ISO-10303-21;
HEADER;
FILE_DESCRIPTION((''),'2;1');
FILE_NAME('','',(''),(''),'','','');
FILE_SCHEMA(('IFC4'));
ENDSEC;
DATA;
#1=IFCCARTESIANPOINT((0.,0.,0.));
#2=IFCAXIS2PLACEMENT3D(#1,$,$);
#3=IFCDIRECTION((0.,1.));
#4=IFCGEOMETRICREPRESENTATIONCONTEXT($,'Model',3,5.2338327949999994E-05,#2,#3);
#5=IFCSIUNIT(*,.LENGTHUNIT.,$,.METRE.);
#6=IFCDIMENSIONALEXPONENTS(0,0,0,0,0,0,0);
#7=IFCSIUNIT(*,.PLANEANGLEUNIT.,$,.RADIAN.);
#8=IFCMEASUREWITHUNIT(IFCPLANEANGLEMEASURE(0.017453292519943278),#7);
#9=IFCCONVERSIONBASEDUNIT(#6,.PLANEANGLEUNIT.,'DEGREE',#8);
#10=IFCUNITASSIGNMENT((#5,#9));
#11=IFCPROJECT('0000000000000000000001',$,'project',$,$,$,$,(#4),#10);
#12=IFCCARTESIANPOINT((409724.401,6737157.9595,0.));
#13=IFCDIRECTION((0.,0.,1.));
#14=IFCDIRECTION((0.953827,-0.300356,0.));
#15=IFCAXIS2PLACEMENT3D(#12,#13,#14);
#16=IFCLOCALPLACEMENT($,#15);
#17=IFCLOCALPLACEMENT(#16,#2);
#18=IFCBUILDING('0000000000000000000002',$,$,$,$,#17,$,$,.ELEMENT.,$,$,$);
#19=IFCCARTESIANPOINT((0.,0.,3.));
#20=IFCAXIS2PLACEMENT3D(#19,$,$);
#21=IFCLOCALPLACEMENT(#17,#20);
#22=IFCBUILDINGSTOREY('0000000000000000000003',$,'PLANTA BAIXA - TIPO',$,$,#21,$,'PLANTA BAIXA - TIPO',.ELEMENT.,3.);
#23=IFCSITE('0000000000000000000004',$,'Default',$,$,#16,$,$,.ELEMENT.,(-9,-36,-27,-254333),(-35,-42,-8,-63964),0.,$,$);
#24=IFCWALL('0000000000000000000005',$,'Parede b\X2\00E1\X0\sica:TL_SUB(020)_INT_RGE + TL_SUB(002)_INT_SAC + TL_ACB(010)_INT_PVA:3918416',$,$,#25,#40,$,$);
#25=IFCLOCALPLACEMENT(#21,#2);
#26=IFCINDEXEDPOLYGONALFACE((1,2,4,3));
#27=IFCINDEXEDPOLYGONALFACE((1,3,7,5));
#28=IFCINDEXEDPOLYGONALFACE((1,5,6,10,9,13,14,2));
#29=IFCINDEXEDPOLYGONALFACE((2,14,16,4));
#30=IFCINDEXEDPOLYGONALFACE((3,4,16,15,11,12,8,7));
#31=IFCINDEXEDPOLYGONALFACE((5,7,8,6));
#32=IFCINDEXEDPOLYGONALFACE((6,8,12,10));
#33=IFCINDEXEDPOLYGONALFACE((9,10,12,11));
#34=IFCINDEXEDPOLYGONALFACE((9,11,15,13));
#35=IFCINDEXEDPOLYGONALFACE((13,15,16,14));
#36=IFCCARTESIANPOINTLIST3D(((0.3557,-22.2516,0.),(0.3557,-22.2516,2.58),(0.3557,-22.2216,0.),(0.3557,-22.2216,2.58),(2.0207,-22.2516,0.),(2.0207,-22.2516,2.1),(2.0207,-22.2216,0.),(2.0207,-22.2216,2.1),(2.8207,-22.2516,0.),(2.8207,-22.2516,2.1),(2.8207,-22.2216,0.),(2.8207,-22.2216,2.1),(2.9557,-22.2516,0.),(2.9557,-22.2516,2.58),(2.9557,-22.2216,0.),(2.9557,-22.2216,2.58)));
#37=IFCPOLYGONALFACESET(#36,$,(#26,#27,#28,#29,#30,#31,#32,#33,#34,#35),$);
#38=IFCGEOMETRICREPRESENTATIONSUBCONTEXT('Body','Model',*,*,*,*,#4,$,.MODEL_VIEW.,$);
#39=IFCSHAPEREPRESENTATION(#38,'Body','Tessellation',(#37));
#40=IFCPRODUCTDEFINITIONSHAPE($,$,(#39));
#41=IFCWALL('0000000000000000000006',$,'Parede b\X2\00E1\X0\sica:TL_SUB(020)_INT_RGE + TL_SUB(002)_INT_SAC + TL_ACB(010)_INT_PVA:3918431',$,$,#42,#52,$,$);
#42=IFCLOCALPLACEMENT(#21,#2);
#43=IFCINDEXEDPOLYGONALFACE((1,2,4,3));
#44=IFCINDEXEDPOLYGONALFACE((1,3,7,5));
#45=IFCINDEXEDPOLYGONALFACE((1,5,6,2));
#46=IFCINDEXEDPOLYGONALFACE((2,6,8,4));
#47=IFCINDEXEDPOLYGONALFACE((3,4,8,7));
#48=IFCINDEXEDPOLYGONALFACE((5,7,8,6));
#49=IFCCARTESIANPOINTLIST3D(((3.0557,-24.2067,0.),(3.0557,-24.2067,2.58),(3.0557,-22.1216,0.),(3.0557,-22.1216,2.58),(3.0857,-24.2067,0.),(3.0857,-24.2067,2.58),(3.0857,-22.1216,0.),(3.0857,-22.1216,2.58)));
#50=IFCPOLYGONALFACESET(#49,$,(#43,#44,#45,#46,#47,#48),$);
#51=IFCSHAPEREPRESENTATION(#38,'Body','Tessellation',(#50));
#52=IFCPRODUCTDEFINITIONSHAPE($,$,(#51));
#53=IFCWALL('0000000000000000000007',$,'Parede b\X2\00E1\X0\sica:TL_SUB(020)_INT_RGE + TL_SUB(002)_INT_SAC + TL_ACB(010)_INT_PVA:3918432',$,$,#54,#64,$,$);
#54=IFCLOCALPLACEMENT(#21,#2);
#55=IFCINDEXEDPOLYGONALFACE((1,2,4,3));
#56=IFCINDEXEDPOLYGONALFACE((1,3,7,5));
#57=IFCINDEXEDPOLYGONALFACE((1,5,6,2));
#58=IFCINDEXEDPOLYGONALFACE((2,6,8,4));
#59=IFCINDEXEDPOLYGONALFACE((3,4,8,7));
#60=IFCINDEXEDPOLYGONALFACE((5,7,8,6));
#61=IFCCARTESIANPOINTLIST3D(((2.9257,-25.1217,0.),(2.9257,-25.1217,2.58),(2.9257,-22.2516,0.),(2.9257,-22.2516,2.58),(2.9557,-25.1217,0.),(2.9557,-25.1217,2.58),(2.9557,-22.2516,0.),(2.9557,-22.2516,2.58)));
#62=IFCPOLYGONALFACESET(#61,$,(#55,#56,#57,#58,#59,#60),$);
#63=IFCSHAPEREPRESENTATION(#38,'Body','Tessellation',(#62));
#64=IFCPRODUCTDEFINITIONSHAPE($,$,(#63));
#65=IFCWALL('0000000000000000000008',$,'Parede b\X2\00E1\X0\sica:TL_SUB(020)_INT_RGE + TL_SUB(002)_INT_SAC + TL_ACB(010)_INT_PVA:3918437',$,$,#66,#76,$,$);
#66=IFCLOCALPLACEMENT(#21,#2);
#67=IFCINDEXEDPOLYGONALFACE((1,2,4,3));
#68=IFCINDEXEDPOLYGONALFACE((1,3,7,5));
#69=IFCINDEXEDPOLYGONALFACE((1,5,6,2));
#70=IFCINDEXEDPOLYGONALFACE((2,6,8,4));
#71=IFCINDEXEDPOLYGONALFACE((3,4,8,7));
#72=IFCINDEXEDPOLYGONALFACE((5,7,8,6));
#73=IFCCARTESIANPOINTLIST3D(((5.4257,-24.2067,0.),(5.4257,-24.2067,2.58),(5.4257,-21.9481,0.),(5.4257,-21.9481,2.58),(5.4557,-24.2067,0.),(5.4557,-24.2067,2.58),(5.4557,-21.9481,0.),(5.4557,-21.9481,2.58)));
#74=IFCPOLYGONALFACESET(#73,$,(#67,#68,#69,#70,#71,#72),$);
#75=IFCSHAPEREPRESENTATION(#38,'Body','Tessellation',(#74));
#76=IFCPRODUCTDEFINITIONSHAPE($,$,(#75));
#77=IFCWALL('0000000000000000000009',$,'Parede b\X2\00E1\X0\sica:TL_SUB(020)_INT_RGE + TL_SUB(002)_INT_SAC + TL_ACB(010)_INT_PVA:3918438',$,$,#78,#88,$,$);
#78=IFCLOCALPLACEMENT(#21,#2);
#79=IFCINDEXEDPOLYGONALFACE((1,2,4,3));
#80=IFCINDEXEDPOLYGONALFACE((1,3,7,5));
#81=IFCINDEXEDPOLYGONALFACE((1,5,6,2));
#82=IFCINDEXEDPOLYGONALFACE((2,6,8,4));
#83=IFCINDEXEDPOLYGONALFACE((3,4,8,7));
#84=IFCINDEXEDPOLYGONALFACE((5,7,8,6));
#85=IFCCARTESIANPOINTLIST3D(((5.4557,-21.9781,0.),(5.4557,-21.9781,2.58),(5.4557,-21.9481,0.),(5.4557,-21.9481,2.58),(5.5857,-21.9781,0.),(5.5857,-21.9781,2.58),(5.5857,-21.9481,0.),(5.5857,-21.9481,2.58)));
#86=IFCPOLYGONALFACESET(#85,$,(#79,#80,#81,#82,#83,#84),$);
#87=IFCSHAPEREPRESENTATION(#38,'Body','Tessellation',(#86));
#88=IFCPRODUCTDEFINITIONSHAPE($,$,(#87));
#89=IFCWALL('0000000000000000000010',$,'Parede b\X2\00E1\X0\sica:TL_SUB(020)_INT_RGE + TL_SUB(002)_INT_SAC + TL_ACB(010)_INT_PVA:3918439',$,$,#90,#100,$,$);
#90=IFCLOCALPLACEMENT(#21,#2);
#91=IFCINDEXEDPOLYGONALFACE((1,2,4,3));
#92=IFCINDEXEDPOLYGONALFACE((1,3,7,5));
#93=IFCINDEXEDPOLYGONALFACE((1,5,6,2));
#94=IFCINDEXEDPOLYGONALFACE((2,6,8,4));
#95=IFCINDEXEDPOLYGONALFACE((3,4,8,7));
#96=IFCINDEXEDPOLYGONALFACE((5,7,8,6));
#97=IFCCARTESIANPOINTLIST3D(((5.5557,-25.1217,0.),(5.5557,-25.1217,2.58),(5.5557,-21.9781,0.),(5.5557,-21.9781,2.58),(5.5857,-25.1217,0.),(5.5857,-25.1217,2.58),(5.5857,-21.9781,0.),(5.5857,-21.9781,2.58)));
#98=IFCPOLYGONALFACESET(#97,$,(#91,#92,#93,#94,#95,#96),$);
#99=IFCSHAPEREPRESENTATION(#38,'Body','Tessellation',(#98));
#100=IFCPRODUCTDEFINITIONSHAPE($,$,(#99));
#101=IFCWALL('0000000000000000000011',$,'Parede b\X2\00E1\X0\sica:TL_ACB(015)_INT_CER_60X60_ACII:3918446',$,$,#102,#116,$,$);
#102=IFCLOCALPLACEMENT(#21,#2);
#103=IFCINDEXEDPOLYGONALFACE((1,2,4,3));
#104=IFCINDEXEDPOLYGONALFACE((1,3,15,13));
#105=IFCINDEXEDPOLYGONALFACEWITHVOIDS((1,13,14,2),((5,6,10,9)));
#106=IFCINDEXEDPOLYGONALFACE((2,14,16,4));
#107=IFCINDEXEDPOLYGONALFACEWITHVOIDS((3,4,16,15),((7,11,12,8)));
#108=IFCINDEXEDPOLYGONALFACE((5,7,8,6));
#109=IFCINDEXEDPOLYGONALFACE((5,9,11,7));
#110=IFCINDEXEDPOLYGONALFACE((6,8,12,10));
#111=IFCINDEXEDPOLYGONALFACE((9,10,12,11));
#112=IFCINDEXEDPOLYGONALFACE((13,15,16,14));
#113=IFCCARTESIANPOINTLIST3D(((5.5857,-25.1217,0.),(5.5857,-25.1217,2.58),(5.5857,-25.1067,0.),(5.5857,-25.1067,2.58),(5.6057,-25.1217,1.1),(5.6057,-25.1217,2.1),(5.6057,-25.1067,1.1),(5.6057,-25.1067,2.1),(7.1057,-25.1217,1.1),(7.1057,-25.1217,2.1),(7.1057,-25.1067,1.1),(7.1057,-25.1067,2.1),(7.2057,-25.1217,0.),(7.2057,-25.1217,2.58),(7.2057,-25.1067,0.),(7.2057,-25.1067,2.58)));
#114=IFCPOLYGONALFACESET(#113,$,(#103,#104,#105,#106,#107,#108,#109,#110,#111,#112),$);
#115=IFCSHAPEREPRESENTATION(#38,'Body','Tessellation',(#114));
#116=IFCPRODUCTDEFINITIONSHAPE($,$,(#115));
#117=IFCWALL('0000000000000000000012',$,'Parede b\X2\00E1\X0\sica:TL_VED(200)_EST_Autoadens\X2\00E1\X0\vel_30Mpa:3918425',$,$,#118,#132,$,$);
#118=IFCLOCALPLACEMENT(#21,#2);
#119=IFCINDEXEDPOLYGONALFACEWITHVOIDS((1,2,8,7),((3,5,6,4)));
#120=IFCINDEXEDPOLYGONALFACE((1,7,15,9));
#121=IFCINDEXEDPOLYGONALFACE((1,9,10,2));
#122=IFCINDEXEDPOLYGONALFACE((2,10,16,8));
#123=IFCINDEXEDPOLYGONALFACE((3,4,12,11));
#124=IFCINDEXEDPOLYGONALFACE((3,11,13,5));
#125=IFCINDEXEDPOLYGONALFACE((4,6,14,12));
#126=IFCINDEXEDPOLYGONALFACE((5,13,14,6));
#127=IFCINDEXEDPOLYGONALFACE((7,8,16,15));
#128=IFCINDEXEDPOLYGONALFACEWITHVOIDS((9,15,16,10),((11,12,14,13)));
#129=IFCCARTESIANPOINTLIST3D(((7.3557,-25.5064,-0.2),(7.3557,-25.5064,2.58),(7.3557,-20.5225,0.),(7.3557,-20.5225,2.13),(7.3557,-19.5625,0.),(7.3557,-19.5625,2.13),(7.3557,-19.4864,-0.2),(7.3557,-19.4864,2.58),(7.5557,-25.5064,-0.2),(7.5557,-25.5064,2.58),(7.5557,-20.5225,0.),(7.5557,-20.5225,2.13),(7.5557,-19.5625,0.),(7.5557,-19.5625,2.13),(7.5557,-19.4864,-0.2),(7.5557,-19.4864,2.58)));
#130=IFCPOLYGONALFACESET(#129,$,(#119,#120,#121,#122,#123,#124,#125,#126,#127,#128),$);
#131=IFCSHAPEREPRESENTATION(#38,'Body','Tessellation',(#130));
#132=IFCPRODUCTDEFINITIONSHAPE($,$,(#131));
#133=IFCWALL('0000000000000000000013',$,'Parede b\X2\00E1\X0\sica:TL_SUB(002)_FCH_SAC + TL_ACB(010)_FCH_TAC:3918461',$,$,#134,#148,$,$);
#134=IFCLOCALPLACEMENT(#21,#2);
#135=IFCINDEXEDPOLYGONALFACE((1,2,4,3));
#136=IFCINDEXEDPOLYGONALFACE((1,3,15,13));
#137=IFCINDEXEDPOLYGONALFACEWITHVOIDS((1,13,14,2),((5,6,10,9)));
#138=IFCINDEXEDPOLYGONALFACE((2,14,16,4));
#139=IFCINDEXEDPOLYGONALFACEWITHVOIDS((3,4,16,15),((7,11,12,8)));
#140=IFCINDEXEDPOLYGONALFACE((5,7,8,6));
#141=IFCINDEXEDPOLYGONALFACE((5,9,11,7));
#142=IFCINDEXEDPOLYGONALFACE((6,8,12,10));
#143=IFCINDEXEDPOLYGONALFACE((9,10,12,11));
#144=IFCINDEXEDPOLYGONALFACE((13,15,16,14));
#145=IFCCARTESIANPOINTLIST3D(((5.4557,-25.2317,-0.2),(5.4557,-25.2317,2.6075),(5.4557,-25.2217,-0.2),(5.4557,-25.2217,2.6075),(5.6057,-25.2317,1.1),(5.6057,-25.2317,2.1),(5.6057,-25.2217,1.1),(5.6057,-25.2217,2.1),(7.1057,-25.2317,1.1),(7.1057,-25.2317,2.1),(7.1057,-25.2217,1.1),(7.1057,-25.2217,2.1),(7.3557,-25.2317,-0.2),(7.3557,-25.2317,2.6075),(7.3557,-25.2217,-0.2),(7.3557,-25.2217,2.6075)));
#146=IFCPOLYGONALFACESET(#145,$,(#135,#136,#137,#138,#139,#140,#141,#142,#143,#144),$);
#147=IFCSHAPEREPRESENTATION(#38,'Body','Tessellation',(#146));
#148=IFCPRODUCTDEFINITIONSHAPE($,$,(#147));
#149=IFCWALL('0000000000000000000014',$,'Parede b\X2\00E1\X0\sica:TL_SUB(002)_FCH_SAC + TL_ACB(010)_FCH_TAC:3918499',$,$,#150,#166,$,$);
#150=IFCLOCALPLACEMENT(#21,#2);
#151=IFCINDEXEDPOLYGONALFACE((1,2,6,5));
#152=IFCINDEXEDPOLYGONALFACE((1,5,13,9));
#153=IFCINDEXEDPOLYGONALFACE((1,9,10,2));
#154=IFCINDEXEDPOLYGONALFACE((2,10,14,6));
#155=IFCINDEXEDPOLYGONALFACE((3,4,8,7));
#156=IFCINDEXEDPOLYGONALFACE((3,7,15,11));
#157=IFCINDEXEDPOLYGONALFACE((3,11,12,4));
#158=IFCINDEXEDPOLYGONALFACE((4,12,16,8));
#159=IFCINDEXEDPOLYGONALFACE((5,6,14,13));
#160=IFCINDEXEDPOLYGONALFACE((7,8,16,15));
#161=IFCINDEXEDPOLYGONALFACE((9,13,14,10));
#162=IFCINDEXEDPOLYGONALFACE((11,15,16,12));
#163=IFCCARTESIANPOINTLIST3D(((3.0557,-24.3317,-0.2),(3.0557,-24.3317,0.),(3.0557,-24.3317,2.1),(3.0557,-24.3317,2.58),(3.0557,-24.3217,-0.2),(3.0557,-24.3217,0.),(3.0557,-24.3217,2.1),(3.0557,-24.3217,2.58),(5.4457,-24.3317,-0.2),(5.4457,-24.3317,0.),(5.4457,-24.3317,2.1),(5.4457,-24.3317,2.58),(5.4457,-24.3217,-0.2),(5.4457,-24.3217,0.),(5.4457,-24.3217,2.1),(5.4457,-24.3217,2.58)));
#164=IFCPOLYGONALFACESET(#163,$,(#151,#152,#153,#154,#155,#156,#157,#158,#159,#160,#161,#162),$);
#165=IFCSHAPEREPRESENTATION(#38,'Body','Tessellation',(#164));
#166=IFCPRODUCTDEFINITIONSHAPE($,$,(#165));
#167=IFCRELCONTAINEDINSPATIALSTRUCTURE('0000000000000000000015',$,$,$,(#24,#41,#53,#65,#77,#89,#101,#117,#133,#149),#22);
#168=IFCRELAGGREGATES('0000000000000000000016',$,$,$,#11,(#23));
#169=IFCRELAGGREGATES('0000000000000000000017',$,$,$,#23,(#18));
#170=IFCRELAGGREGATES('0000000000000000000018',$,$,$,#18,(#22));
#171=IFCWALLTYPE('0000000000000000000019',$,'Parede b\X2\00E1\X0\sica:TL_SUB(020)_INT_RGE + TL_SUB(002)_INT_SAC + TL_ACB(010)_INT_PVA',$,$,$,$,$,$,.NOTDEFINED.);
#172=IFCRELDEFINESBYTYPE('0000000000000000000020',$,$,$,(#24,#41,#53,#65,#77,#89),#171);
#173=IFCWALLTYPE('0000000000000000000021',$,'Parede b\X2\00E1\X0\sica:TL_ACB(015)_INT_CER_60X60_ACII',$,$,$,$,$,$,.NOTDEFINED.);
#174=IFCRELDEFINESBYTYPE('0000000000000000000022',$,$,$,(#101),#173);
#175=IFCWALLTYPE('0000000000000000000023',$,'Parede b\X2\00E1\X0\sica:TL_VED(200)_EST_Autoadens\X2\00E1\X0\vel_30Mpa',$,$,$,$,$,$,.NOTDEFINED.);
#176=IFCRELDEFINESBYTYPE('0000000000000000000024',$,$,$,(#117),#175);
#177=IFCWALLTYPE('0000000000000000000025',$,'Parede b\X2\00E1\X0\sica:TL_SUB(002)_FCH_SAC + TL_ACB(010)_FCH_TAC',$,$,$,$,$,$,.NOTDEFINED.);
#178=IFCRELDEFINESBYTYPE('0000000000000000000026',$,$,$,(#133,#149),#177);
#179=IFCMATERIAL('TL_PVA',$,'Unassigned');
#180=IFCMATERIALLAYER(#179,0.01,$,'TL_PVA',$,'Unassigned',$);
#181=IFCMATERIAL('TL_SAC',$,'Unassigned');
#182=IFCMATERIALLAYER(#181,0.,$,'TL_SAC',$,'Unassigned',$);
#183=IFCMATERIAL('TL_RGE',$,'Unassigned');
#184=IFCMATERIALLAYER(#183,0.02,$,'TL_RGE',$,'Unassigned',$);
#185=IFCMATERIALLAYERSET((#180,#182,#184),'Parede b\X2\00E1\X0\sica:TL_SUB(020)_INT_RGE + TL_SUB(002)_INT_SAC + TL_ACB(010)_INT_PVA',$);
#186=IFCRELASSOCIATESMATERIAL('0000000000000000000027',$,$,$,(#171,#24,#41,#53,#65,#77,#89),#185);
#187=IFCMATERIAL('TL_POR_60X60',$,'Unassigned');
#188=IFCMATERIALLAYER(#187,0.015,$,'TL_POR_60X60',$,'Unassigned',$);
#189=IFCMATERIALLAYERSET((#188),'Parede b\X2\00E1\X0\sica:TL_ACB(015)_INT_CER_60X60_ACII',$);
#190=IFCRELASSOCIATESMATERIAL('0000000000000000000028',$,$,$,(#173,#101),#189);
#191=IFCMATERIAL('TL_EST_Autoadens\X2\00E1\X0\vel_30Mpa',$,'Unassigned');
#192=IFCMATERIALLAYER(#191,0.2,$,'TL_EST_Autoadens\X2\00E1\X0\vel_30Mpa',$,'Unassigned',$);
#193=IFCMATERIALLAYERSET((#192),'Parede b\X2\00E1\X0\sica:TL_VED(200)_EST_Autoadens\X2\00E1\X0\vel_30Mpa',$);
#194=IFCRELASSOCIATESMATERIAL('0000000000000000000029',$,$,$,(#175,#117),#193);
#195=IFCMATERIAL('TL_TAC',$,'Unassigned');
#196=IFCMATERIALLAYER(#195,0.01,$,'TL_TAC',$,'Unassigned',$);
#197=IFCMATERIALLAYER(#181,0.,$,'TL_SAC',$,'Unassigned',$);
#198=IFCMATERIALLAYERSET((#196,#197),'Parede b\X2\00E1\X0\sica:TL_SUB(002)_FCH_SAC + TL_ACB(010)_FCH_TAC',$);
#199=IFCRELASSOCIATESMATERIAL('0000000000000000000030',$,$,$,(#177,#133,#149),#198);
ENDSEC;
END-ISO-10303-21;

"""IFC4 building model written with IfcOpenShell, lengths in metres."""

from ifc_helpers import new_model, entity, si_unit, converted_unit, direction, frame, frame_2d, origin, place, context, subcontext, project, spatial, rectangle, extrude, material, layer, layer_set, layer_usage, type_object, element, save


model = new_model("IFC4")

# Units and contexts
model_context = context("Model", 3, precision=5.2338327949999994e-05, world=origin(), true_north=direction((0.0, 1.0)))
body_context = subcontext(model_context, "Body", "Model", "MODEL_VIEW")
ifc_project = project(units=[si_unit("LENGTHUNIT", "METRE"), converted_unit("PLANEANGLEUNIT", "DEGREE", entity("IfcPlaneAngleMeasure", 0.017453292519943278), si_unit("PLANEANGLEUNIT", "RADIAN"), dimensions=[0, 0, 0, 0, 0, 0, 0])], contexts=[model_context])

# Site, building, storey
site_placement = place(None, frame((409724.401, 6737157.9595, 0.0), z_axis=(0.0, 0.0, 1.0), x_axis=(0.953827, -0.300356, 0.0)))
site = spatial("IfcSite", under=ifc_project, at=site_placement, Name="Default", CompositionType="ELEMENT", RefLatitude=(-9, -36, -27, -254333), RefLongitude=(-35, -42, -8, -63964), RefElevation=0.0)
building_placement = place(site_placement, origin())
building = spatial("IfcBuilding", under=site, at=building_placement, CompositionType="ELEMENT")
storey_placement = place(building_placement, frame((0.0, 0.0, 3.0)))
storey = spatial("IfcBuildingStorey", under=building, at=storey_placement, Name="PLANTA BAIXA - TIPO", LongName="PLANTA BAIXA - TIPO", CompositionType="ELEMENT", Elevation=3.0)

# Shared definitions
ifc_material_1 = material(Name="TL_EST_Autoadensável_30Mpa", Category="Unassigned")

# Wall, opening
ifc_material_2 = material(Name="TL_PVA", Category="Unassigned")
ifc_layer_1 = layer(ifc_material_2, 0.01, Name="TL_PVA", Category="Unassigned")
ifc_material_3 = material(Name="TL_SAC", Category="Unassigned")
ifc_layer_2 = layer(ifc_material_3, 0.0, Name="TL_SAC", Category="Unassigned")
ifc_material_4 = material(Name="TL_RGE", Category="Unassigned")
ifc_layer_3 = layer(ifc_material_4, 0.02, Name="TL_RGE", Category="Unassigned")
ifc_layer_set_1 = layer_set([ifc_layer_1, ifc_layer_2, ifc_layer_3], Name="Parede básica:TL_SUB(020)_INT_RGE + TL_SUB(002)_INT_SAC + TL_ACB(010)_INT_PVA")
ifc_layer_usage_1 = layer_usage(ifc_layer_set_1, "AXIS2", "NEGATIVE", 0.015)
wall_type_1 = type_object("IfcWallType", Name="Parede básica:TL_SUB(020)_INT_RGE + TL_SUB(002)_INT_SAC + TL_ACB(010)_INT_PVA", PredefinedType="NOTDEFINED", material=ifc_layer_set_1)
wall_1_placement = place(storey_placement, frame((2.9557, -22.2366, 0.0), z_axis=(0.0, 0.0, 1.0), x_axis=(-1.0, 0.0, 0.0)))
wall_1 = element("IfcWall", 1, at=wall_1_placement, inside=storey, type_object=wall_type_1, material=ifc_layer_usage_1, Name="Parede básica:TL_SUB(020)_INT_RGE + TL_SUB(002)_INT_SAC + TL_ACB(010)_INT_PVA:3918416", context=body_context, shape_type="SweptSolid", body=[
    extrude(rectangle(XDim=2.6, YDim=0.03, at=frame_2d((1.3, 0.0), x_axis=(-1.0, 0.0))), origin(), (0.0, 0.0, 1.0), 2.58),
])
opening_1_placement = place(wall_1_placement, frame((2.9557, -22.2366, 0.0)))
element("IfcOpeningElement", 2, at=opening_1_placement, cuts=wall_1, PredefinedType="OPENING", context=body_context, shape_type="SweptSolid", body=[
    extrude(rectangle(XDim=2.1, YDim=0.8, at=frame_2d((0.0, 0.0), x_axis=(1.0, 0.0))), frame((-2.4207, 20.5976, 1.05), z_axis=(0.0, 1.0, 0.0), x_axis=(0.0, 0.0, 1.0)), (0.0, 0.0, 1.0), 3.048),
])

# Walls
ifc_layer_usage_2 = layer_usage(ifc_layer_set_1, "AXIS2", "POSITIVE", -0.015)
wall_2_placement = place(storey_placement, frame((3.0707, -24.2067, 0.0), z_axis=(0.0, 0.0, 1.0), x_axis=(0.0, 1.0, 0.0)))
element("IfcWall", 3, at=wall_2_placement, inside=storey, type_object=wall_type_1, material=ifc_layer_usage_2, Name="Parede básica:TL_SUB(020)_INT_RGE + TL_SUB(002)_INT_SAC + TL_ACB(010)_INT_PVA:3918431", context=body_context, shape_type="SweptSolid", body=[
    extrude(rectangle(XDim=2.0851, YDim=0.03, at=frame_2d((1.0426, 0.0), x_axis=(-1.0, 0.0))), origin(), (0.0, 0.0, 1.0), 2.58),
])
ifc_layer_usage_3 = layer_usage(ifc_layer_set_1, "AXIS2", "POSITIVE", -0.015)
wall_3_placement = place(storey_placement, frame((2.9407, -22.2516, 0.0), z_axis=(0.0, 0.0, 1.0), x_axis=(0.0, -1.0, 0.0)))
element("IfcWall", 4, at=wall_3_placement, inside=storey, type_object=wall_type_1, material=ifc_layer_usage_3, Name="Parede básica:TL_SUB(020)_INT_RGE + TL_SUB(002)_INT_SAC + TL_ACB(010)_INT_PVA:3918432", context=body_context, shape_type="SweptSolid", body=[
    extrude(rectangle(XDim=2.8701, YDim=0.03, at=frame_2d((1.4351, 0.0), x_axis=(-1.0, 0.0))), origin(), (0.0, 0.0, 1.0), 2.58),
])
ifc_layer_usage_4 = layer_usage(ifc_layer_set_1, "AXIS2", "POSITIVE", -0.015)
wall_4_placement = place(storey_placement, frame((5.4407, -21.9481, 0.0), z_axis=(0.0, 0.0, 1.0), x_axis=(0.0, -1.0, 0.0)))
element("IfcWall", 5, at=wall_4_placement, inside=storey, type_object=wall_type_1, material=ifc_layer_usage_4, Name="Parede básica:TL_SUB(020)_INT_RGE + TL_SUB(002)_INT_SAC + TL_ACB(010)_INT_PVA:3918437", context=body_context, shape_type="SweptSolid", body=[
    extrude(rectangle(XDim=2.2587, YDim=0.03, at=frame_2d((1.1293, 0.0), x_axis=(-1.0, 0.0))), origin(), (0.0, 0.0, 1.0), 2.58),
])
ifc_layer_usage_5 = layer_usage(ifc_layer_set_1, "AXIS2", "POSITIVE", -0.015)
wall_5_placement = place(storey_placement, frame((5.5857, -21.9631, 0.0), z_axis=(0.0, 0.0, 1.0), x_axis=(-1.0, 0.0, 0.0)))
element("IfcWall", 6, at=wall_5_placement, inside=storey, type_object=wall_type_1, material=ifc_layer_usage_5, Name="Parede básica:TL_SUB(020)_INT_RGE + TL_SUB(002)_INT_SAC + TL_ACB(010)_INT_PVA:3918438", context=body_context, shape_type="SweptSolid", body=[
    extrude(rectangle(XDim=0.13, YDim=0.03, at=frame_2d((0.065, 0.0), x_axis=(-1.0, 0.0))), origin(), (0.0, 0.0, 1.0), 2.58),
])
ifc_layer_usage_6 = layer_usage(ifc_layer_set_1, "AXIS2", "POSITIVE", -0.015)
wall_6_placement = place(storey_placement, frame((5.5707, -25.1217, 0.0), z_axis=(0.0, 0.0, 1.0), x_axis=(0.0, 1.0, 0.0)))
element("IfcWall", 7, at=wall_6_placement, inside=storey, type_object=wall_type_1, material=ifc_layer_usage_6, Name="Parede básica:TL_SUB(020)_INT_RGE + TL_SUB(002)_INT_SAC + TL_ACB(010)_INT_PVA:3918439", context=body_context, shape_type="SweptSolid", body=[
    extrude(rectangle(XDim=3.1437, YDim=0.03, at=frame_2d((1.5718, 0.0), x_axis=(-1.0, 0.0))), origin(), (0.0, 0.0, 1.0), 2.58),
])

# Walls, openings
ifc_material_5 = material(Name="TL_POR_60X60", Category="Unassigned")
ifc_layer_4 = layer(ifc_material_5, 0.015, Name="TL_POR_60X60", Category="Unassigned")
ifc_layer_set_2 = layer_set([ifc_layer_4], Name="Parede básica:TL_ACB(015)_INT_CER_60X60_ACII")
ifc_layer_usage_7 = layer_usage(ifc_layer_set_2, "AXIS2", "POSITIVE", -0.0075)
wall_type_2 = type_object("IfcWallType", Name="Parede básica:TL_ACB(015)_INT_CER_60X60_ACII", PredefinedType="NOTDEFINED", material=ifc_layer_set_2)
wall_7_placement = place(storey_placement, frame((7.2057, -25.1142, 0.0), z_axis=(0.0, 0.0, 1.0), x_axis=(-1.0, 0.0, 0.0)))
wall_7 = element("IfcWall", 8, at=wall_7_placement, inside=storey, type_object=wall_type_2, material=ifc_layer_usage_7, Name="Parede básica:TL_ACB(015)_INT_CER_60X60_ACII:3918446", context=body_context, shape_type="SweptSolid", body=[
    extrude(rectangle(XDim=1.62, YDim=0.015, at=frame_2d((0.81, 0.0), x_axis=(-1.0, 0.0))), origin(), (0.0, 0.0, 1.0), 2.58),
])
opening_2_placement = place(wall_7_placement, frame((7.2057, -25.1142, 1.1)))
element("IfcOpeningElement", 9, at=opening_2_placement, cuts=wall_7, PredefinedType="OPENING", context=body_context, shape_type="SweptSolid", body=[
    extrude(rectangle(XDim=1.0, YDim=1.5, at=frame_2d((0.0, 0.0), x_axis=(0.0, 1.0))), frame((-6.3557, 23.5977, 0.5), z_axis=(0.0, 1.0, 0.0), x_axis=(1.0, 0.0, 0.0)), (0.0, 0.0, 1.0), 3.048),
])
ifc_layer_5 = layer(ifc_material_1, 0.2, Name="TL_EST_Autoadensável_30Mpa", Category="Unassigned")
ifc_layer_set_3 = layer_set([ifc_layer_5], Name="Parede básica:TL_VED(200)_EST_Autoadensável_30Mpa")
ifc_layer_usage_8 = layer_usage(ifc_layer_set_3, "AXIS2", "POSITIVE", -0.1)
wall_type_3 = type_object("IfcWallType", Name="Parede básica:TL_VED(200)_EST_Autoadensável_30Mpa", PredefinedType="NOTDEFINED", material=ifc_layer_set_3)
wall_8_placement = place(storey_placement, frame((7.4557, -25.5064, -0.2), z_axis=(0.0, 0.0, 1.0), x_axis=(0.0, 1.0, 0.0)))
wall_8 = element("IfcWall", 10, at=wall_8_placement, inside=storey, type_object=wall_type_3, material=ifc_layer_usage_8, Name="Parede básica:TL_VED(200)_EST_Autoadensável_30Mpa:3918425", context=body_context, shape_type="SweptSolid", body=[
    extrude(rectangle(XDim=6.02, YDim=0.2, at=frame_2d((3.01, 0.0), x_axis=(-1.0, 0.0))), origin(), (0.0, 0.0, 1.0), 2.78),
])
opening_3_placement = place(wall_8_placement, frame((4.9838, -0.1, 0.2)))
element("IfcOpeningElement", 11, at=opening_3_placement, cuts=wall_8, PredefinedType="OPENING", context=body_context, shape_type="SweptSolid", body=[
    extrude(rectangle(XDim=2.13, YDim=0.96, at=frame_2d((1.065, 0.48), x_axis=(1.0, 0.0))), frame((0.0, 0.0, 0.0), z_axis=(0.0, 1.0, 0.0), x_axis=(0.0, 0.0, 1.0)), (0.0, 0.0, 1.0), 0.2),
])
ifc_material_6 = material(Name="TL_TAC", Category="Unassigned")
ifc_layer_6 = layer(ifc_material_6, 0.01, Name="TL_TAC", Category="Unassigned")
ifc_layer_7 = layer(ifc_material_3, 0.0, Name="TL_SAC", Category="Unassigned")
ifc_layer_set_4 = layer_set([ifc_layer_6, ifc_layer_7], Name="Parede básica:TL_SUB(002)_FCH_SAC + TL_ACB(010)_FCH_TAC")
ifc_layer_usage_9 = layer_usage(ifc_layer_set_4, "AXIS2", "POSITIVE", -0.005)
wall_type_4 = type_object("IfcWallType", Name="Parede básica:TL_SUB(002)_FCH_SAC + TL_ACB(010)_FCH_TAC", PredefinedType="NOTDEFINED", material=ifc_layer_set_4)
wall_9_placement = place(storey_placement, frame((7.3557, -25.2267, -0.2), z_axis=(0.0, 0.0, 1.0), x_axis=(-1.0, 0.0, 0.0)))
wall_9 = element("IfcWall", 12, at=wall_9_placement, inside=storey, type_object=wall_type_4, material=ifc_layer_usage_9, Name="Parede básica:TL_SUB(002)_FCH_SAC + TL_ACB(010)_FCH_TAC:3918461", context=body_context, shape_type="SweptSolid", body=[
    extrude(rectangle(XDim=1.9, YDim=0.01, at=frame_2d((0.95, 0.0), x_axis=(-1.0, 0.0))), origin(), (0.0, 0.0, 1.0), 2.8075),
])
opening_4_placement = place(wall_9_placement, frame((7.3557, -25.2267, 1.3)))
element("IfcOpeningElement", 13, at=opening_4_placement, cuts=wall_9, PredefinedType="OPENING", context=body_context, shape_type="SweptSolid", body=[
    extrude(rectangle(XDim=1.0, YDim=1.5, at=frame_2d((0.0, 0.0), x_axis=(0.0, 1.0))), frame((-6.3557, 23.5977, 0.5), z_axis=(0.0, 1.0, 0.0), x_axis=(1.0, 0.0, 0.0)), (0.0, 0.0, 1.0), 3.048),
])
ifc_layer_usage_10 = layer_usage(ifc_layer_set_4, "AXIS2", "NEGATIVE", 0.005)
wall_10_placement = place(storey_placement, frame((5.4457, -24.3267, -0.2), z_axis=(0.0, 0.0, 1.0), x_axis=(-1.0, 0.0, 0.0)))
wall_10 = element("IfcWall", 14, at=wall_10_placement, inside=storey, type_object=wall_type_4, material=ifc_layer_usage_10, Name="Parede básica:TL_SUB(002)_FCH_SAC + TL_ACB(010)_FCH_TAC:3918499", context=body_context, shape_type="SweptSolid", body=[
    extrude(rectangle(XDim=2.39, YDim=0.01, at=frame_2d((1.195, 0.0), x_axis=(-1.0, 0.0))), origin(), (0.0, 0.0, 1.0), 2.78),
])
opening_5_placement = place(wall_10_placement, frame((5.4457, -24.3267, 0.2)))
element("IfcOpeningElement", 15, at=opening_5_placement, cuts=wall_10, PredefinedType="OPENING", context=body_context, shape_type="SweptSolid", body=[
    extrude(rectangle(XDim=2.1, YDim=2.4, at=frame_2d((0.0, 0.0), x_axis=(0.0, 1.0))), frame((-4.2557, 22.7977, 1.05), z_axis=(0.0, 1.0, 0.0), x_axis=(-1.0, 0.0, 0.0)), (0.0, 0.0, 1.0), 3.048),
])

save(model, "model.ifc")
